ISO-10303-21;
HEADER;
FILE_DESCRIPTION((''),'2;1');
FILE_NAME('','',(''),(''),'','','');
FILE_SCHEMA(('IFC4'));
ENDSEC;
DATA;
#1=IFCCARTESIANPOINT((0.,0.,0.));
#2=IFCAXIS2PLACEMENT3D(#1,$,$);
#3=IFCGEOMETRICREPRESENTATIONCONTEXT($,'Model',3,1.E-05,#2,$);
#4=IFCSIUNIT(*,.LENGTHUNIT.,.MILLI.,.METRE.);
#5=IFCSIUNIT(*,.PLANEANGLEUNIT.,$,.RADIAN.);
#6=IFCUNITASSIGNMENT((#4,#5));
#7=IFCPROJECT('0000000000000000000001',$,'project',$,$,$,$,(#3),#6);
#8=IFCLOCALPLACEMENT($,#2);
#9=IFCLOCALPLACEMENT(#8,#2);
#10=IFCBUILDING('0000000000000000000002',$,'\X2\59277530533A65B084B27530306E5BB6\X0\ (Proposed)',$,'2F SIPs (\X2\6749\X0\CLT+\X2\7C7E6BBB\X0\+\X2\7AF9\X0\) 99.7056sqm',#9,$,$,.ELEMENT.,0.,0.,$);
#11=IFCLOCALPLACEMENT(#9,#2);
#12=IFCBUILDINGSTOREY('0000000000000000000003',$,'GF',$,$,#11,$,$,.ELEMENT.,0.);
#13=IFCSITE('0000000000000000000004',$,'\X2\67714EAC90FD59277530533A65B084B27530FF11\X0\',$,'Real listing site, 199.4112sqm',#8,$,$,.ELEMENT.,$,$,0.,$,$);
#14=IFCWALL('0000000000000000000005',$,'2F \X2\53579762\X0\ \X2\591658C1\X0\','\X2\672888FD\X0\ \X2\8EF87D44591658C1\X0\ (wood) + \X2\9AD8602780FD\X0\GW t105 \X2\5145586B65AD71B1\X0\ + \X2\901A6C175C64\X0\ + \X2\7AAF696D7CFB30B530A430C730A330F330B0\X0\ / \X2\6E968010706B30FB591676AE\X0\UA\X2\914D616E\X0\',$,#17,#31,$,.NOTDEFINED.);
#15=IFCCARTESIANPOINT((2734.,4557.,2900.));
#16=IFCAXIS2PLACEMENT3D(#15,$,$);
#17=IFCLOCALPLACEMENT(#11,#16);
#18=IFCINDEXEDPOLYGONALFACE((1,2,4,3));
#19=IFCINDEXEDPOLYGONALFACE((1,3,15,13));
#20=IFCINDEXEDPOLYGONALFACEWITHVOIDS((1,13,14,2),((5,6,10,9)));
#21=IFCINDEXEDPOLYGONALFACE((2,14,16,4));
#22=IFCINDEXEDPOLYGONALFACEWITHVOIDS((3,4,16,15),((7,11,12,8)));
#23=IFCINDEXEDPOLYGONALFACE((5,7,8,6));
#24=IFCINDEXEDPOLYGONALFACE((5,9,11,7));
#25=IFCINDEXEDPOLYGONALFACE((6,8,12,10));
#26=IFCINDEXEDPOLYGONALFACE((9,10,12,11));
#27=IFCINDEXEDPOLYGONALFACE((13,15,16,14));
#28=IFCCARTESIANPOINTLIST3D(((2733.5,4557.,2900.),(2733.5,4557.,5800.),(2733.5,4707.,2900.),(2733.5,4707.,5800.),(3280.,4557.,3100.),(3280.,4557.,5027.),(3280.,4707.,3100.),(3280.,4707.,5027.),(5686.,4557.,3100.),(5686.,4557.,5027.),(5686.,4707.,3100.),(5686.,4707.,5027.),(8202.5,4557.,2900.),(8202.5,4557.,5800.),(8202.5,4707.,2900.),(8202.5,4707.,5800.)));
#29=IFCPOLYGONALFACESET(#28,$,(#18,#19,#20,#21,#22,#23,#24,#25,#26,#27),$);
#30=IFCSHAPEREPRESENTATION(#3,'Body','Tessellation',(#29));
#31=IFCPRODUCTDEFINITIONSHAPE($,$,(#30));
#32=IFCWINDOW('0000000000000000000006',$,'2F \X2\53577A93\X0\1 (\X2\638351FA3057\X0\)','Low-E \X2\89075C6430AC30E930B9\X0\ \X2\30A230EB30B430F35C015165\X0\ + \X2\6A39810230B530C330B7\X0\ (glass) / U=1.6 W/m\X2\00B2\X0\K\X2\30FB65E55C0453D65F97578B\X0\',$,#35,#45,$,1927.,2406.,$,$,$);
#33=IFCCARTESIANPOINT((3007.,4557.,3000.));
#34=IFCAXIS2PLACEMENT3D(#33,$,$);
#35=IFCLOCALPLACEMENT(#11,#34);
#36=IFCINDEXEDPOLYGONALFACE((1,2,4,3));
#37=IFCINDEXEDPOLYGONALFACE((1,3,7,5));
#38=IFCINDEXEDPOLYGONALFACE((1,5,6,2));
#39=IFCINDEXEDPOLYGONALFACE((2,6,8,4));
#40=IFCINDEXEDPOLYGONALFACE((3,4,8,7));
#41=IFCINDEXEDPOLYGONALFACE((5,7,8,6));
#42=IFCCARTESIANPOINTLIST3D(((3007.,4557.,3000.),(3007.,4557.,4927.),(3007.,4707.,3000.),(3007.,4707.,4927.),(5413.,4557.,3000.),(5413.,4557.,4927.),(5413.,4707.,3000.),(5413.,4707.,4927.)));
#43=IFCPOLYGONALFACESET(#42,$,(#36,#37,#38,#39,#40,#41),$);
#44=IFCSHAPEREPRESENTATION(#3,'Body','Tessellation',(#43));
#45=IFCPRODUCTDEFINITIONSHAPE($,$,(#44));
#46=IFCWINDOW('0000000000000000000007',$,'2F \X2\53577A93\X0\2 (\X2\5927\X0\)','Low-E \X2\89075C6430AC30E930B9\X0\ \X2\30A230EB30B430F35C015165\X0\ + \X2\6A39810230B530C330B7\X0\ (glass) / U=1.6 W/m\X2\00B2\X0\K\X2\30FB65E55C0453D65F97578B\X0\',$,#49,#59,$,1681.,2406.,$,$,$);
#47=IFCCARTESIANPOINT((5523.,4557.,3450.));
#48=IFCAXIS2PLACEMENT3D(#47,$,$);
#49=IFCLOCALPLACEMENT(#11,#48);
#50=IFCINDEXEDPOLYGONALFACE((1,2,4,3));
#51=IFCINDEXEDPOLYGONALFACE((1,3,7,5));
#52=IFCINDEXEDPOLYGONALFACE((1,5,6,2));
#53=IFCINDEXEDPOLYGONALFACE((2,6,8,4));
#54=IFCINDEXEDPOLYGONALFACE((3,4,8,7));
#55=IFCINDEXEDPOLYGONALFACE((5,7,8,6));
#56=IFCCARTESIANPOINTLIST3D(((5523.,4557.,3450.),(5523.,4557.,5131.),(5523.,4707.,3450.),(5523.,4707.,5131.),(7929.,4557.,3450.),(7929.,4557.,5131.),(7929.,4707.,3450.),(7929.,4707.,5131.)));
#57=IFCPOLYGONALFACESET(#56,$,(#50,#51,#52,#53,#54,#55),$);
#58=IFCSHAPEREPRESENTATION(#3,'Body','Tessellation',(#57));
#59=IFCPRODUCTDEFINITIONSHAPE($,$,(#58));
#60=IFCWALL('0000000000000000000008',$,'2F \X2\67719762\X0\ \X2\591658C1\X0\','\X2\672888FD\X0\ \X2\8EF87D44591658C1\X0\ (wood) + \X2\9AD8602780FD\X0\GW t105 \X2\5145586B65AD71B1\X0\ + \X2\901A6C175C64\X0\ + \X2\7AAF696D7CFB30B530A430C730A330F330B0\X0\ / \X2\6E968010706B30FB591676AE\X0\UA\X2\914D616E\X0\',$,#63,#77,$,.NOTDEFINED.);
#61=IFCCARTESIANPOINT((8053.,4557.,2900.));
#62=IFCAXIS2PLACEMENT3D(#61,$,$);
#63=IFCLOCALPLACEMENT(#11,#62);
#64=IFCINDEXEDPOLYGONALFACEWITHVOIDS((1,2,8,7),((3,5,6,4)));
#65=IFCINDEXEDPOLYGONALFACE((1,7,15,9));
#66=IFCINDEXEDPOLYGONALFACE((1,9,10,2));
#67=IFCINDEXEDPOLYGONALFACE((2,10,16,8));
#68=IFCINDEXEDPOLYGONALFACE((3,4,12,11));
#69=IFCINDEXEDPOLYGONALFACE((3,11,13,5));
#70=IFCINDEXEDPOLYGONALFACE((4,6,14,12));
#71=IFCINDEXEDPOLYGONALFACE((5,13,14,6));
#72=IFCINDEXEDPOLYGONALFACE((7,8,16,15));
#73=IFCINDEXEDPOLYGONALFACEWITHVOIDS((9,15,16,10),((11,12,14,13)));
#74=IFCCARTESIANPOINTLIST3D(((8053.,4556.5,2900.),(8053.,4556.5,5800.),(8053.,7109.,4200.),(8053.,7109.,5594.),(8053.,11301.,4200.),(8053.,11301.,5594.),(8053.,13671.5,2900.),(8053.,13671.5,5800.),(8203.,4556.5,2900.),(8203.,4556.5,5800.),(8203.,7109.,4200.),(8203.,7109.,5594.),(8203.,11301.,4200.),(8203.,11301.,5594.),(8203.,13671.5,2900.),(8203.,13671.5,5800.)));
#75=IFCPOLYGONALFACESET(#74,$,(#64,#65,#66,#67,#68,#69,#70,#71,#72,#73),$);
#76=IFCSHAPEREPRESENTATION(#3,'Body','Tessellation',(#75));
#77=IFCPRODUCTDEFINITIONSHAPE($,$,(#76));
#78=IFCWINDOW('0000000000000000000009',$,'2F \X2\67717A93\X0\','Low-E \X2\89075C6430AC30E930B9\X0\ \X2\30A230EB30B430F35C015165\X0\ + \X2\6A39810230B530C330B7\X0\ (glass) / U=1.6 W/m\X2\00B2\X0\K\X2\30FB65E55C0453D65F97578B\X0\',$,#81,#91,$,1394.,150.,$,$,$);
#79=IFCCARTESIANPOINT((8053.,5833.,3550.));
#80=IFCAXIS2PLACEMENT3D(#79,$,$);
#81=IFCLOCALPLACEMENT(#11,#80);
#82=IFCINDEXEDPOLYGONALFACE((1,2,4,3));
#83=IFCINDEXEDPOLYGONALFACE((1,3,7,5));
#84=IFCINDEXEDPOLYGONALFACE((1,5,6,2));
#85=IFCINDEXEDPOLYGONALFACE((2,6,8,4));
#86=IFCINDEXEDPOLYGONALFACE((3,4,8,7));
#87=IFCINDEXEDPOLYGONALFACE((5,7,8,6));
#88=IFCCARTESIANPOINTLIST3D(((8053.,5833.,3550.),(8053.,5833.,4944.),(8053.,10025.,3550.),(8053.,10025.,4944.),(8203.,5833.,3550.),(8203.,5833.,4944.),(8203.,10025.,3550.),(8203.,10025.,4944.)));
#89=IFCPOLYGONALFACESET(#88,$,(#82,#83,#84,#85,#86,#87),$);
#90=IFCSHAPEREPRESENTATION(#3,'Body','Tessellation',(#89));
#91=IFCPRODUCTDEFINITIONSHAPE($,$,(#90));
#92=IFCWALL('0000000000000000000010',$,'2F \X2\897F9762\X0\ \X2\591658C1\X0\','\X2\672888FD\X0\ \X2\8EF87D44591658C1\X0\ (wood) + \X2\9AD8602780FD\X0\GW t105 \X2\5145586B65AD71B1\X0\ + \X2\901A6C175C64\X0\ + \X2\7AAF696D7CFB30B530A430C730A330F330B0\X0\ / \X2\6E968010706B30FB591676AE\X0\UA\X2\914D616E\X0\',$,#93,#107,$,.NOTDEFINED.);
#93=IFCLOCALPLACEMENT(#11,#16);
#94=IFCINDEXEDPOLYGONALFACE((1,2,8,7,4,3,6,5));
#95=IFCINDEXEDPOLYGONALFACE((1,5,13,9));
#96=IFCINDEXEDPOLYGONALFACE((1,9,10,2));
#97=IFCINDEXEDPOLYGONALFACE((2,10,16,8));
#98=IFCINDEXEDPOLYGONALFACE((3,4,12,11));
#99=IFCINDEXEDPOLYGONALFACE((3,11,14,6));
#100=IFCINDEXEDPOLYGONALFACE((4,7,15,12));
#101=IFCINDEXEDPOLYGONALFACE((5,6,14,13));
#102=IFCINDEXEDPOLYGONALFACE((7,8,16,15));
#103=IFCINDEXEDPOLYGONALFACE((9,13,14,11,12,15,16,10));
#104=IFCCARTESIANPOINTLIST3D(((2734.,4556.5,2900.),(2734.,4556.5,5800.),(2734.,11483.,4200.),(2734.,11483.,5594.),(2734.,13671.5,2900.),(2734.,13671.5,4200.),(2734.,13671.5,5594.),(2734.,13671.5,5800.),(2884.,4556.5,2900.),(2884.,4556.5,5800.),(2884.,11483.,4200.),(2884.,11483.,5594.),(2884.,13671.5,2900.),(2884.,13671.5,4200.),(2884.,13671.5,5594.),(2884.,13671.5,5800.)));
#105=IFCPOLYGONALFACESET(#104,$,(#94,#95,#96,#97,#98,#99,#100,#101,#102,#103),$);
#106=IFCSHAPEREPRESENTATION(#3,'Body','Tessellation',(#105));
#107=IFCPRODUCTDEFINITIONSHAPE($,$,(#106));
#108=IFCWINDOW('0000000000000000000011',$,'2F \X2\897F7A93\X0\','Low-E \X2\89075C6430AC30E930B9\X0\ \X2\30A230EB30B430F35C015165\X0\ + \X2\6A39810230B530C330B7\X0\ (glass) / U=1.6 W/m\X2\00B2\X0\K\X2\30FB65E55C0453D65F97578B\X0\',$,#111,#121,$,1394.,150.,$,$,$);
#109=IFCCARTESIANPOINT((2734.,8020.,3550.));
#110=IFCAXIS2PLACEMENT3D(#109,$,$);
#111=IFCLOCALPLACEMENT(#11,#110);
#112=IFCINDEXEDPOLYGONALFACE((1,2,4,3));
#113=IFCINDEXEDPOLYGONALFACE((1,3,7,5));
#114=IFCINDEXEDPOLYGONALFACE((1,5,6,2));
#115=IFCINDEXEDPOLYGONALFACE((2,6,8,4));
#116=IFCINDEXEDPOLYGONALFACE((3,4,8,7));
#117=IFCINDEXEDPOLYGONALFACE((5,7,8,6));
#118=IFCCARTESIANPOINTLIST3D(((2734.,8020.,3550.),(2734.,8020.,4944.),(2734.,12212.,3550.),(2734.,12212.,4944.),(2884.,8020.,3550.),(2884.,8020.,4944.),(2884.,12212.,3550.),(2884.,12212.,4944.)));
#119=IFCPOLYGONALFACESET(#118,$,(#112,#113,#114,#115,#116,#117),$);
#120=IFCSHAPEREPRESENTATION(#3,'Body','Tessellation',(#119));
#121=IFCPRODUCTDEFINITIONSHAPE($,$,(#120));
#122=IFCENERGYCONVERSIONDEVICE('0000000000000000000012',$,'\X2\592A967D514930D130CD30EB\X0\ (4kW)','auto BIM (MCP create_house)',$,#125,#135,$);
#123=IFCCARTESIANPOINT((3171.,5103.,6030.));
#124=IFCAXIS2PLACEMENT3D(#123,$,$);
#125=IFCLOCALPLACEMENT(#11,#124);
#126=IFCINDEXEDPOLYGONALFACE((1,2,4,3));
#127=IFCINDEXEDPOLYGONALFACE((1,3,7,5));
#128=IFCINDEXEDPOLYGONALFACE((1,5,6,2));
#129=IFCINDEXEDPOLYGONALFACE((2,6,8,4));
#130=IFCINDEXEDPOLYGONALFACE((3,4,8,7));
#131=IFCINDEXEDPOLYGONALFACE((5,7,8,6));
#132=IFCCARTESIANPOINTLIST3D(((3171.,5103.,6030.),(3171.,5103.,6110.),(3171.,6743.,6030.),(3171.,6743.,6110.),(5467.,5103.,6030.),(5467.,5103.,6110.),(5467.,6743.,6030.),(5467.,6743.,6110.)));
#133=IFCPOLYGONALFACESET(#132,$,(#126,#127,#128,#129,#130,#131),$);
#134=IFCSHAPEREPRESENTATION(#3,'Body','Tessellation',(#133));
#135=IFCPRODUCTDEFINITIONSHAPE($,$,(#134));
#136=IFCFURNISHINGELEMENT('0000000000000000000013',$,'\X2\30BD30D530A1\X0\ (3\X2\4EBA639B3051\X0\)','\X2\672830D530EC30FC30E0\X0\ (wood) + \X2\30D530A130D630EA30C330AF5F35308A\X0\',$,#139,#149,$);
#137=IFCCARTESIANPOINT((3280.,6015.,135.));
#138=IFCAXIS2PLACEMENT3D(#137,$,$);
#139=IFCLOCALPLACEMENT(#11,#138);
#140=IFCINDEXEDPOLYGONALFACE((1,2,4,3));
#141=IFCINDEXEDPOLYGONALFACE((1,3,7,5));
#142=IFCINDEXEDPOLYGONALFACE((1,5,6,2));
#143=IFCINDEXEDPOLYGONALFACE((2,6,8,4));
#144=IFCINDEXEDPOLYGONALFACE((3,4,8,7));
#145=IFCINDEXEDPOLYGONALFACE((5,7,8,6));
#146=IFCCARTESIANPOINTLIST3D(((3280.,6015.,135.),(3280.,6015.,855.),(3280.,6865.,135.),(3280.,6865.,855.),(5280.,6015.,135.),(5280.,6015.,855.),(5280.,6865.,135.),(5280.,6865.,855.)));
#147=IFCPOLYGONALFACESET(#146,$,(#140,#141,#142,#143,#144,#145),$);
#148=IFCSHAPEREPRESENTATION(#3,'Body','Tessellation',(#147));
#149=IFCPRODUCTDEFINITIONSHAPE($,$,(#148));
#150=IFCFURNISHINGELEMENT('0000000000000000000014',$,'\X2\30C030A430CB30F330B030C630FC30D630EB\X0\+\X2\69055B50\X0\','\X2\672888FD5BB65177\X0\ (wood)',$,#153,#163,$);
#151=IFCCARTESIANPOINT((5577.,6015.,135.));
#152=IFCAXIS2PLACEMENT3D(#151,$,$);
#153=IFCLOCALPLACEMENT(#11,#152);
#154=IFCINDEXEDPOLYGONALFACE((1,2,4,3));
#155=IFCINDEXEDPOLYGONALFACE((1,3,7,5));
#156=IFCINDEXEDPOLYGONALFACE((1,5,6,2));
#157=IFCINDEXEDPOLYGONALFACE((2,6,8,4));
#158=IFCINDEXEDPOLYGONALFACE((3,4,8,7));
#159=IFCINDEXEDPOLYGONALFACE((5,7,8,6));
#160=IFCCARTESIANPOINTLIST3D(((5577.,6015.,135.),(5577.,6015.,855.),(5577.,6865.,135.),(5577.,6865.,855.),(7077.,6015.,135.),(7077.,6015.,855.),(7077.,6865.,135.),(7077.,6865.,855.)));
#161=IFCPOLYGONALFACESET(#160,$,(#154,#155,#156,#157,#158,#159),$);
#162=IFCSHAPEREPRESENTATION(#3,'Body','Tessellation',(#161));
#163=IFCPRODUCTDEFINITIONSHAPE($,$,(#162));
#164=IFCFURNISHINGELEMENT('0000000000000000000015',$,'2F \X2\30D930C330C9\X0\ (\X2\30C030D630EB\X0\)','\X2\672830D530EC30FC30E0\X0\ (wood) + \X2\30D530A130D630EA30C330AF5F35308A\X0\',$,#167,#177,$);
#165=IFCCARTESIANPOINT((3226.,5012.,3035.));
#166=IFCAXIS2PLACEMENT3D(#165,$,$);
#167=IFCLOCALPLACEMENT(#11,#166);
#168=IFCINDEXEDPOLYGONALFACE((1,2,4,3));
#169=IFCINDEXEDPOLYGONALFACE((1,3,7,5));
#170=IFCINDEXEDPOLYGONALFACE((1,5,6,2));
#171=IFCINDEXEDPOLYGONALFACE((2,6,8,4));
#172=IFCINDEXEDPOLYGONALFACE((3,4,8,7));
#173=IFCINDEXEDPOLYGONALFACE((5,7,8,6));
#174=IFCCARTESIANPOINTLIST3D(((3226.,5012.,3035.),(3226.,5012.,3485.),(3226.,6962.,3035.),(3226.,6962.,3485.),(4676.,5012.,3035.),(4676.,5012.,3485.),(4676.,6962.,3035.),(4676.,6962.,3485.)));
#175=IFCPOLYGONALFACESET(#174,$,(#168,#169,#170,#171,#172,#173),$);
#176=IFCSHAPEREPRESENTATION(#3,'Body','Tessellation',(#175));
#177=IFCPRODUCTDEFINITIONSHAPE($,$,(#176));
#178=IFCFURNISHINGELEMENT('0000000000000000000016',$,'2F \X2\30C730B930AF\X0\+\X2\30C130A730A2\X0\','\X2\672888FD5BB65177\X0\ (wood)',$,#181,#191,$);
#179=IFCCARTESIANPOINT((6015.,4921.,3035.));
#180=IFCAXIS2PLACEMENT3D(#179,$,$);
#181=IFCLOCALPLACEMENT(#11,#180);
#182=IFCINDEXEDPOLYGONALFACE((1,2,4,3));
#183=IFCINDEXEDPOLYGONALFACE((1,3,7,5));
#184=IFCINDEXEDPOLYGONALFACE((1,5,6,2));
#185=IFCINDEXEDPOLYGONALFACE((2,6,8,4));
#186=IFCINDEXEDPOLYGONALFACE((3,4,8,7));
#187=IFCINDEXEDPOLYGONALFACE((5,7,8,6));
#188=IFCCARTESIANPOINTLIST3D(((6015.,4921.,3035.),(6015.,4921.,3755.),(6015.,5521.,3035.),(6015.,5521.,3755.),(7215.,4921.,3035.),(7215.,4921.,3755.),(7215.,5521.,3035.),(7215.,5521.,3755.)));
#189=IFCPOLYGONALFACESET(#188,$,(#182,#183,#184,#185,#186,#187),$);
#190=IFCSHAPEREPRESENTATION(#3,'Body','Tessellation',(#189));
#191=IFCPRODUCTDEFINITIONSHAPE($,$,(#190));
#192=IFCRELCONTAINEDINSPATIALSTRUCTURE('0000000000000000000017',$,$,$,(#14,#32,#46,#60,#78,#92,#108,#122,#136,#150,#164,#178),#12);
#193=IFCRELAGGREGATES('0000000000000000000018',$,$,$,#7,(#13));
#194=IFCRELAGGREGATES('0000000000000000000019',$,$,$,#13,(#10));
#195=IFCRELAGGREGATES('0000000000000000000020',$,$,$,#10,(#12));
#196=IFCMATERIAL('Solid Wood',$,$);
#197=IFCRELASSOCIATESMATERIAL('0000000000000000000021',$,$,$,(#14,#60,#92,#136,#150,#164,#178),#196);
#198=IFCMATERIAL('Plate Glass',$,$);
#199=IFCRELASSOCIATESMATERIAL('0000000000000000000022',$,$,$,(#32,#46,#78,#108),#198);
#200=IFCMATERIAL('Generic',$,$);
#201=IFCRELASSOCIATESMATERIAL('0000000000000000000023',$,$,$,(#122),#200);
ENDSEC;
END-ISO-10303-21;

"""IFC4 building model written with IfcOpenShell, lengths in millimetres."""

from ifc_helpers import new_model, si_unit, frame, frame_2d, origin, place, context, project, spatial, rectangle, extrude, material, element, fill, save


model = new_model("IFC4")

# Units and contexts
model_context = context("Model", 3, precision=1e-05, world=origin())
ifc_project = project(units=[si_unit("LENGTHUNIT", "METRE", prefix="MILLI"), si_unit("PLANEANGLEUNIT", "RADIAN")], contexts=[model_context])

# Site, building, storey
site_placement = place(None, origin())
site = spatial("IfcSite", under=ifc_project, at=site_placement, Name="東京都大田区新蒲田１", ObjectType="Real listing site, 199.4112sqm", CompositionType="ELEMENT", RefElevation=0.0)
building_placement = place(site_placement, origin())
building = spatial("IfcBuilding", under=site, at=building_placement, Name="大田区新蒲田の家 (Proposed)", ObjectType="2F SIPs (杉CLT+籾殻+竹) 99.7056sqm", CompositionType="ELEMENT", ElevationOfRefHeight=0.0, ElevationOfTerrain=0.0)
storey_placement = place(building_placement, origin())
storey = spatial("IfcBuildingStorey", under=building, at=storey_placement, Name="GF", CompositionType="ELEMENT", Elevation=0.0)

# Shared definitions
ifc_material_1 = material(Name="Solid Wood")

# Wall, openings, windows
wall_1_placement = place(storey_placement, frame((2734.0, 4557.0, 2900.0)))
wall_1 = element("IfcWall", 1, at=wall_1_placement, inside=storey, material=ifc_material_1, Name="2F 南面 外壁", Description="木製 軸組外壁 (wood) + 高性能GW t105 充填断熱 + 通気層 + 窯業系サイディング / 準耐火・外皮UA配慮", PredefinedType="NOTDEFINED", context=model_context, shape_type="SweptSolid", body=[
    extrude(rectangle(XDim=5469.0, YDim=150.0, at=frame_2d((2734.0, 75.0))), frame((2734.0, 4557.0, 2900.0)), (0.0, 0.0, 1.0), 2900.0),
])
opening_1_placement = place(storey_placement, frame((3007.0, 4557.0, 3000.0)))
opening_1 = element("IfcOpeningElement", 2, at=opening_1_placement, cuts=wall_1, PredefinedType="NOTDEFINED", context=model_context, shape_type="SweptSolid", body=[
    extrude(rectangle(XDim=2406.0, YDim=150.0, at=frame_2d((1203.0, 75.0))), frame((3007.0, 4557.0, 3000.0)), (0.0, 0.0, 1.0), 1927.0),
])
opening_2_placement = place(storey_placement, frame((5523.0, 4557.0, 3450.0)))
opening_2 = element("IfcOpeningElement", 3, at=opening_2_placement, cuts=wall_1, PredefinedType="NOTDEFINED", context=model_context, shape_type="SweptSolid", body=[
    extrude(rectangle(XDim=2406.0, YDim=150.0, at=frame_2d((1203.0, 75.0))), frame((5523.0, 4557.0, 3450.0)), (0.0, 0.0, 1.0), 1681.0),
])
ifc_material_2 = material(Name="Plate Glass")
window_1_placement = place(storey_placement, frame((3007.0, 4557.0, 3000.0)))
window_1 = element("IfcWindow", 4, at=window_1_placement, inside=storey, material=ifc_material_2, Name="2F 南窓1 (掃出し)", Description="Low-E 複層ガラス アルゴン封入 + 樹脂サッシ (glass) / U=1.6 W/m²K・日射取得型", OverallHeight=1927.0, OverallWidth=2406.0, context=model_context, shape_type="SweptSolid", body=[
    extrude(rectangle(XDim=2406.0, YDim=150.0, at=frame_2d((1203.0, 75.0))), frame((3007.0, 4557.0, 3000.0)), (0.0, 0.0, 1.0), 1927.0),
])
fill(opening_1, window_1)
window_2_placement = place(storey_placement, frame((5523.0, 4557.0, 3450.0)))
window_2 = element("IfcWindow", 5, at=window_2_placement, inside=storey, material=ifc_material_2, Name="2F 南窓2 (大)", Description="Low-E 複層ガラス アルゴン封入 + 樹脂サッシ (glass) / U=1.6 W/m²K・日射取得型", OverallHeight=1681.0, OverallWidth=2406.0, context=model_context, shape_type="SweptSolid", body=[
    extrude(rectangle(XDim=2406.0, YDim=150.0, at=frame_2d((1203.0, 75.0))), frame((5523.0, 4557.0, 3450.0)), (0.0, 0.0, 1.0), 1681.0),
])
fill(opening_2, window_2)

# Walls, openings, windows
wall_2_placement = place(storey_placement, frame((8053.0, 4557.0, 2900.0)))
wall_2 = element("IfcWall", 6, at=wall_2_placement, inside=storey, material=ifc_material_1, Name="2F 東面 外壁", Description="木製 軸組外壁 (wood) + 高性能GW t105 充填断熱 + 通気層 + 窯業系サイディング / 準耐火・外皮UA配慮", PredefinedType="NOTDEFINED", context=model_context, shape_type="SweptSolid", body=[
    extrude(rectangle(XDim=150.0, YDim=9115.0, at=frame_2d((75.0, 4557.0))), frame((8053.0, 4557.0, 2900.0)), (0.0, 0.0, 1.0), 2900.0),
])
opening_3_placement = place(storey_placement, frame((8053.0, 5833.0, 3550.0)))
opening_3 = element("IfcOpeningElement", 7, at=opening_3_placement, cuts=wall_2, PredefinedType="NOTDEFINED", context=model_context, shape_type="SweptSolid", body=[
    extrude(rectangle(XDim=150.0, YDim=4192.0, at=frame_2d((75.0, 2096.0))), frame((8053.0, 5833.0, 3550.0)), (0.0, 0.0, 1.0), 1394.0),
])
window_3_placement = place(storey_placement, frame((8053.0, 5833.0, 3550.0)))
window_3 = element("IfcWindow", 8, at=window_3_placement, inside=storey, material=ifc_material_2, Name="2F 東窓", Description="Low-E 複層ガラス アルゴン封入 + 樹脂サッシ (glass) / U=1.6 W/m²K・日射取得型", OverallHeight=1394.0, OverallWidth=150.0, context=model_context, shape_type="SweptSolid", body=[
    extrude(rectangle(XDim=150.0, YDim=4192.0, at=frame_2d((75.0, 2096.0))), frame((8053.0, 5833.0, 3550.0)), (0.0, 0.0, 1.0), 1394.0),
])
fill(opening_3, window_3)
wall_3_placement = place(storey_placement, frame((2734.0, 4557.0, 2900.0)))
wall_3 = element("IfcWall", 9, at=wall_3_placement, inside=storey, material=ifc_material_1, Name="2F 西面 外壁", Description="木製 軸組外壁 (wood) + 高性能GW t105 充填断熱 + 通気層 + 窯業系サイディング / 準耐火・外皮UA配慮", PredefinedType="NOTDEFINED", context=model_context, shape_type="SweptSolid", body=[
    extrude(rectangle(XDim=150.0, YDim=9115.0, at=frame_2d((75.0, 4557.0))), frame((2734.0, 4557.0, 2900.0)), (0.0, 0.0, 1.0), 2900.0),
])
opening_4_placement = place(storey_placement, frame((2734.0, 8020.0, 3550.0)))
opening_4 = element("IfcOpeningElement", 10, at=opening_4_placement, cuts=wall_3, PredefinedType="NOTDEFINED", context=model_context, shape_type="SweptSolid", body=[
    extrude(rectangle(XDim=150.0, YDim=4192.0, at=frame_2d((75.0, 2096.0))), frame((2734.0, 8020.0, 3550.0)), (0.0, 0.0, 1.0), 1394.0),
])
window_4_placement = place(storey_placement, frame((2734.0, 8020.0, 3550.0)))
window_4 = element("IfcWindow", 11, at=window_4_placement, inside=storey, material=ifc_material_2, Name="2F 西窓", Description="Low-E 複層ガラス アルゴン封入 + 樹脂サッシ (glass) / U=1.6 W/m²K・日射取得型", OverallHeight=1394.0, OverallWidth=150.0, context=model_context, shape_type="SweptSolid", body=[
    extrude(rectangle(XDim=150.0, YDim=4192.0, at=frame_2d((75.0, 2096.0))), frame((2734.0, 8020.0, 3550.0)), (0.0, 0.0, 1.0), 1394.0),
])
fill(opening_4, window_4)

# Shared definitions
ifc_material_3 = material(Name="Generic")

# Energy conversion device
energy_conversion_device_placement = place(storey_placement, frame((3171.0, 5103.0, 6030.0)))
element("IfcEnergyConversionDevice", 12, at=energy_conversion_device_placement, inside=storey, material=ifc_material_3, Name="太陽光パネル (4kW)", Description="auto BIM (MCP create_house)", context=model_context, shape_type="SweptSolid", body=[
    extrude(rectangle(XDim=2296.0, YDim=1640.0, at=frame_2d((1148.0, 820.0))), frame((3171.0, 5103.0, 6030.0)), (0.0, 0.0, 1.0), 80.0),
])

# Furnishing elements
furnishing_1_placement = place(storey_placement, frame((3280.0, 6015.0, 135.0)))
element("IfcFurnishingElement", 13, at=furnishing_1_placement, inside=storey, material=ifc_material_1, Name="ソファ (3人掛け)", Description="木フレーム (wood) + ファブリック張り", context=model_context, shape_type="SweptSolid", body=[
    extrude(rectangle(XDim=2000.0, YDim=850.0, at=frame_2d((1000.0, 425.0))), frame((3280.0, 6015.0, 135.0)), (0.0, 0.0, 1.0), 720.0),
])
furnishing_2_placement = place(storey_placement, frame((5577.0, 6015.0, 135.0)))
element("IfcFurnishingElement", 14, at=furnishing_2_placement, inside=storey, material=ifc_material_1, Name="ダイニングテーブル+椅子", Description="木製家具 (wood)", context=model_context, shape_type="SweptSolid", body=[
    extrude(rectangle(XDim=1500.0, YDim=850.0, at=frame_2d((750.0, 425.0))), frame((5577.0, 6015.0, 135.0)), (0.0, 0.0, 1.0), 720.0),
])
furnishing_3_placement = place(storey_placement, frame((3226.0, 5012.0, 3035.0)))
element("IfcFurnishingElement", 15, at=furnishing_3_placement, inside=storey, material=ifc_material_1, Name="2F ベッド (ダブル)", Description="木フレーム (wood) + ファブリック張り", context=model_context, shape_type="SweptSolid", body=[
    extrude(rectangle(XDim=1450.0, YDim=1950.0, at=frame_2d((725.0, 975.0))), frame((3226.0, 5012.0, 3035.0)), (0.0, 0.0, 1.0), 450.0),
])
furnishing_4_placement = place(storey_placement, frame((6015.0, 4921.0, 3035.0)))
element("IfcFurnishingElement", 16, at=furnishing_4_placement, inside=storey, material=ifc_material_1, Name="2F デスク+チェア", Description="木製家具 (wood)", context=model_context, shape_type="SweptSolid", body=[
    extrude(rectangle(XDim=1200.0, YDim=600.0, at=frame_2d((600.0, 300.0))), frame((6015.0, 4921.0, 3035.0)), (0.0, 0.0, 1.0), 720.0),
])

save(model, "model.ifc")
